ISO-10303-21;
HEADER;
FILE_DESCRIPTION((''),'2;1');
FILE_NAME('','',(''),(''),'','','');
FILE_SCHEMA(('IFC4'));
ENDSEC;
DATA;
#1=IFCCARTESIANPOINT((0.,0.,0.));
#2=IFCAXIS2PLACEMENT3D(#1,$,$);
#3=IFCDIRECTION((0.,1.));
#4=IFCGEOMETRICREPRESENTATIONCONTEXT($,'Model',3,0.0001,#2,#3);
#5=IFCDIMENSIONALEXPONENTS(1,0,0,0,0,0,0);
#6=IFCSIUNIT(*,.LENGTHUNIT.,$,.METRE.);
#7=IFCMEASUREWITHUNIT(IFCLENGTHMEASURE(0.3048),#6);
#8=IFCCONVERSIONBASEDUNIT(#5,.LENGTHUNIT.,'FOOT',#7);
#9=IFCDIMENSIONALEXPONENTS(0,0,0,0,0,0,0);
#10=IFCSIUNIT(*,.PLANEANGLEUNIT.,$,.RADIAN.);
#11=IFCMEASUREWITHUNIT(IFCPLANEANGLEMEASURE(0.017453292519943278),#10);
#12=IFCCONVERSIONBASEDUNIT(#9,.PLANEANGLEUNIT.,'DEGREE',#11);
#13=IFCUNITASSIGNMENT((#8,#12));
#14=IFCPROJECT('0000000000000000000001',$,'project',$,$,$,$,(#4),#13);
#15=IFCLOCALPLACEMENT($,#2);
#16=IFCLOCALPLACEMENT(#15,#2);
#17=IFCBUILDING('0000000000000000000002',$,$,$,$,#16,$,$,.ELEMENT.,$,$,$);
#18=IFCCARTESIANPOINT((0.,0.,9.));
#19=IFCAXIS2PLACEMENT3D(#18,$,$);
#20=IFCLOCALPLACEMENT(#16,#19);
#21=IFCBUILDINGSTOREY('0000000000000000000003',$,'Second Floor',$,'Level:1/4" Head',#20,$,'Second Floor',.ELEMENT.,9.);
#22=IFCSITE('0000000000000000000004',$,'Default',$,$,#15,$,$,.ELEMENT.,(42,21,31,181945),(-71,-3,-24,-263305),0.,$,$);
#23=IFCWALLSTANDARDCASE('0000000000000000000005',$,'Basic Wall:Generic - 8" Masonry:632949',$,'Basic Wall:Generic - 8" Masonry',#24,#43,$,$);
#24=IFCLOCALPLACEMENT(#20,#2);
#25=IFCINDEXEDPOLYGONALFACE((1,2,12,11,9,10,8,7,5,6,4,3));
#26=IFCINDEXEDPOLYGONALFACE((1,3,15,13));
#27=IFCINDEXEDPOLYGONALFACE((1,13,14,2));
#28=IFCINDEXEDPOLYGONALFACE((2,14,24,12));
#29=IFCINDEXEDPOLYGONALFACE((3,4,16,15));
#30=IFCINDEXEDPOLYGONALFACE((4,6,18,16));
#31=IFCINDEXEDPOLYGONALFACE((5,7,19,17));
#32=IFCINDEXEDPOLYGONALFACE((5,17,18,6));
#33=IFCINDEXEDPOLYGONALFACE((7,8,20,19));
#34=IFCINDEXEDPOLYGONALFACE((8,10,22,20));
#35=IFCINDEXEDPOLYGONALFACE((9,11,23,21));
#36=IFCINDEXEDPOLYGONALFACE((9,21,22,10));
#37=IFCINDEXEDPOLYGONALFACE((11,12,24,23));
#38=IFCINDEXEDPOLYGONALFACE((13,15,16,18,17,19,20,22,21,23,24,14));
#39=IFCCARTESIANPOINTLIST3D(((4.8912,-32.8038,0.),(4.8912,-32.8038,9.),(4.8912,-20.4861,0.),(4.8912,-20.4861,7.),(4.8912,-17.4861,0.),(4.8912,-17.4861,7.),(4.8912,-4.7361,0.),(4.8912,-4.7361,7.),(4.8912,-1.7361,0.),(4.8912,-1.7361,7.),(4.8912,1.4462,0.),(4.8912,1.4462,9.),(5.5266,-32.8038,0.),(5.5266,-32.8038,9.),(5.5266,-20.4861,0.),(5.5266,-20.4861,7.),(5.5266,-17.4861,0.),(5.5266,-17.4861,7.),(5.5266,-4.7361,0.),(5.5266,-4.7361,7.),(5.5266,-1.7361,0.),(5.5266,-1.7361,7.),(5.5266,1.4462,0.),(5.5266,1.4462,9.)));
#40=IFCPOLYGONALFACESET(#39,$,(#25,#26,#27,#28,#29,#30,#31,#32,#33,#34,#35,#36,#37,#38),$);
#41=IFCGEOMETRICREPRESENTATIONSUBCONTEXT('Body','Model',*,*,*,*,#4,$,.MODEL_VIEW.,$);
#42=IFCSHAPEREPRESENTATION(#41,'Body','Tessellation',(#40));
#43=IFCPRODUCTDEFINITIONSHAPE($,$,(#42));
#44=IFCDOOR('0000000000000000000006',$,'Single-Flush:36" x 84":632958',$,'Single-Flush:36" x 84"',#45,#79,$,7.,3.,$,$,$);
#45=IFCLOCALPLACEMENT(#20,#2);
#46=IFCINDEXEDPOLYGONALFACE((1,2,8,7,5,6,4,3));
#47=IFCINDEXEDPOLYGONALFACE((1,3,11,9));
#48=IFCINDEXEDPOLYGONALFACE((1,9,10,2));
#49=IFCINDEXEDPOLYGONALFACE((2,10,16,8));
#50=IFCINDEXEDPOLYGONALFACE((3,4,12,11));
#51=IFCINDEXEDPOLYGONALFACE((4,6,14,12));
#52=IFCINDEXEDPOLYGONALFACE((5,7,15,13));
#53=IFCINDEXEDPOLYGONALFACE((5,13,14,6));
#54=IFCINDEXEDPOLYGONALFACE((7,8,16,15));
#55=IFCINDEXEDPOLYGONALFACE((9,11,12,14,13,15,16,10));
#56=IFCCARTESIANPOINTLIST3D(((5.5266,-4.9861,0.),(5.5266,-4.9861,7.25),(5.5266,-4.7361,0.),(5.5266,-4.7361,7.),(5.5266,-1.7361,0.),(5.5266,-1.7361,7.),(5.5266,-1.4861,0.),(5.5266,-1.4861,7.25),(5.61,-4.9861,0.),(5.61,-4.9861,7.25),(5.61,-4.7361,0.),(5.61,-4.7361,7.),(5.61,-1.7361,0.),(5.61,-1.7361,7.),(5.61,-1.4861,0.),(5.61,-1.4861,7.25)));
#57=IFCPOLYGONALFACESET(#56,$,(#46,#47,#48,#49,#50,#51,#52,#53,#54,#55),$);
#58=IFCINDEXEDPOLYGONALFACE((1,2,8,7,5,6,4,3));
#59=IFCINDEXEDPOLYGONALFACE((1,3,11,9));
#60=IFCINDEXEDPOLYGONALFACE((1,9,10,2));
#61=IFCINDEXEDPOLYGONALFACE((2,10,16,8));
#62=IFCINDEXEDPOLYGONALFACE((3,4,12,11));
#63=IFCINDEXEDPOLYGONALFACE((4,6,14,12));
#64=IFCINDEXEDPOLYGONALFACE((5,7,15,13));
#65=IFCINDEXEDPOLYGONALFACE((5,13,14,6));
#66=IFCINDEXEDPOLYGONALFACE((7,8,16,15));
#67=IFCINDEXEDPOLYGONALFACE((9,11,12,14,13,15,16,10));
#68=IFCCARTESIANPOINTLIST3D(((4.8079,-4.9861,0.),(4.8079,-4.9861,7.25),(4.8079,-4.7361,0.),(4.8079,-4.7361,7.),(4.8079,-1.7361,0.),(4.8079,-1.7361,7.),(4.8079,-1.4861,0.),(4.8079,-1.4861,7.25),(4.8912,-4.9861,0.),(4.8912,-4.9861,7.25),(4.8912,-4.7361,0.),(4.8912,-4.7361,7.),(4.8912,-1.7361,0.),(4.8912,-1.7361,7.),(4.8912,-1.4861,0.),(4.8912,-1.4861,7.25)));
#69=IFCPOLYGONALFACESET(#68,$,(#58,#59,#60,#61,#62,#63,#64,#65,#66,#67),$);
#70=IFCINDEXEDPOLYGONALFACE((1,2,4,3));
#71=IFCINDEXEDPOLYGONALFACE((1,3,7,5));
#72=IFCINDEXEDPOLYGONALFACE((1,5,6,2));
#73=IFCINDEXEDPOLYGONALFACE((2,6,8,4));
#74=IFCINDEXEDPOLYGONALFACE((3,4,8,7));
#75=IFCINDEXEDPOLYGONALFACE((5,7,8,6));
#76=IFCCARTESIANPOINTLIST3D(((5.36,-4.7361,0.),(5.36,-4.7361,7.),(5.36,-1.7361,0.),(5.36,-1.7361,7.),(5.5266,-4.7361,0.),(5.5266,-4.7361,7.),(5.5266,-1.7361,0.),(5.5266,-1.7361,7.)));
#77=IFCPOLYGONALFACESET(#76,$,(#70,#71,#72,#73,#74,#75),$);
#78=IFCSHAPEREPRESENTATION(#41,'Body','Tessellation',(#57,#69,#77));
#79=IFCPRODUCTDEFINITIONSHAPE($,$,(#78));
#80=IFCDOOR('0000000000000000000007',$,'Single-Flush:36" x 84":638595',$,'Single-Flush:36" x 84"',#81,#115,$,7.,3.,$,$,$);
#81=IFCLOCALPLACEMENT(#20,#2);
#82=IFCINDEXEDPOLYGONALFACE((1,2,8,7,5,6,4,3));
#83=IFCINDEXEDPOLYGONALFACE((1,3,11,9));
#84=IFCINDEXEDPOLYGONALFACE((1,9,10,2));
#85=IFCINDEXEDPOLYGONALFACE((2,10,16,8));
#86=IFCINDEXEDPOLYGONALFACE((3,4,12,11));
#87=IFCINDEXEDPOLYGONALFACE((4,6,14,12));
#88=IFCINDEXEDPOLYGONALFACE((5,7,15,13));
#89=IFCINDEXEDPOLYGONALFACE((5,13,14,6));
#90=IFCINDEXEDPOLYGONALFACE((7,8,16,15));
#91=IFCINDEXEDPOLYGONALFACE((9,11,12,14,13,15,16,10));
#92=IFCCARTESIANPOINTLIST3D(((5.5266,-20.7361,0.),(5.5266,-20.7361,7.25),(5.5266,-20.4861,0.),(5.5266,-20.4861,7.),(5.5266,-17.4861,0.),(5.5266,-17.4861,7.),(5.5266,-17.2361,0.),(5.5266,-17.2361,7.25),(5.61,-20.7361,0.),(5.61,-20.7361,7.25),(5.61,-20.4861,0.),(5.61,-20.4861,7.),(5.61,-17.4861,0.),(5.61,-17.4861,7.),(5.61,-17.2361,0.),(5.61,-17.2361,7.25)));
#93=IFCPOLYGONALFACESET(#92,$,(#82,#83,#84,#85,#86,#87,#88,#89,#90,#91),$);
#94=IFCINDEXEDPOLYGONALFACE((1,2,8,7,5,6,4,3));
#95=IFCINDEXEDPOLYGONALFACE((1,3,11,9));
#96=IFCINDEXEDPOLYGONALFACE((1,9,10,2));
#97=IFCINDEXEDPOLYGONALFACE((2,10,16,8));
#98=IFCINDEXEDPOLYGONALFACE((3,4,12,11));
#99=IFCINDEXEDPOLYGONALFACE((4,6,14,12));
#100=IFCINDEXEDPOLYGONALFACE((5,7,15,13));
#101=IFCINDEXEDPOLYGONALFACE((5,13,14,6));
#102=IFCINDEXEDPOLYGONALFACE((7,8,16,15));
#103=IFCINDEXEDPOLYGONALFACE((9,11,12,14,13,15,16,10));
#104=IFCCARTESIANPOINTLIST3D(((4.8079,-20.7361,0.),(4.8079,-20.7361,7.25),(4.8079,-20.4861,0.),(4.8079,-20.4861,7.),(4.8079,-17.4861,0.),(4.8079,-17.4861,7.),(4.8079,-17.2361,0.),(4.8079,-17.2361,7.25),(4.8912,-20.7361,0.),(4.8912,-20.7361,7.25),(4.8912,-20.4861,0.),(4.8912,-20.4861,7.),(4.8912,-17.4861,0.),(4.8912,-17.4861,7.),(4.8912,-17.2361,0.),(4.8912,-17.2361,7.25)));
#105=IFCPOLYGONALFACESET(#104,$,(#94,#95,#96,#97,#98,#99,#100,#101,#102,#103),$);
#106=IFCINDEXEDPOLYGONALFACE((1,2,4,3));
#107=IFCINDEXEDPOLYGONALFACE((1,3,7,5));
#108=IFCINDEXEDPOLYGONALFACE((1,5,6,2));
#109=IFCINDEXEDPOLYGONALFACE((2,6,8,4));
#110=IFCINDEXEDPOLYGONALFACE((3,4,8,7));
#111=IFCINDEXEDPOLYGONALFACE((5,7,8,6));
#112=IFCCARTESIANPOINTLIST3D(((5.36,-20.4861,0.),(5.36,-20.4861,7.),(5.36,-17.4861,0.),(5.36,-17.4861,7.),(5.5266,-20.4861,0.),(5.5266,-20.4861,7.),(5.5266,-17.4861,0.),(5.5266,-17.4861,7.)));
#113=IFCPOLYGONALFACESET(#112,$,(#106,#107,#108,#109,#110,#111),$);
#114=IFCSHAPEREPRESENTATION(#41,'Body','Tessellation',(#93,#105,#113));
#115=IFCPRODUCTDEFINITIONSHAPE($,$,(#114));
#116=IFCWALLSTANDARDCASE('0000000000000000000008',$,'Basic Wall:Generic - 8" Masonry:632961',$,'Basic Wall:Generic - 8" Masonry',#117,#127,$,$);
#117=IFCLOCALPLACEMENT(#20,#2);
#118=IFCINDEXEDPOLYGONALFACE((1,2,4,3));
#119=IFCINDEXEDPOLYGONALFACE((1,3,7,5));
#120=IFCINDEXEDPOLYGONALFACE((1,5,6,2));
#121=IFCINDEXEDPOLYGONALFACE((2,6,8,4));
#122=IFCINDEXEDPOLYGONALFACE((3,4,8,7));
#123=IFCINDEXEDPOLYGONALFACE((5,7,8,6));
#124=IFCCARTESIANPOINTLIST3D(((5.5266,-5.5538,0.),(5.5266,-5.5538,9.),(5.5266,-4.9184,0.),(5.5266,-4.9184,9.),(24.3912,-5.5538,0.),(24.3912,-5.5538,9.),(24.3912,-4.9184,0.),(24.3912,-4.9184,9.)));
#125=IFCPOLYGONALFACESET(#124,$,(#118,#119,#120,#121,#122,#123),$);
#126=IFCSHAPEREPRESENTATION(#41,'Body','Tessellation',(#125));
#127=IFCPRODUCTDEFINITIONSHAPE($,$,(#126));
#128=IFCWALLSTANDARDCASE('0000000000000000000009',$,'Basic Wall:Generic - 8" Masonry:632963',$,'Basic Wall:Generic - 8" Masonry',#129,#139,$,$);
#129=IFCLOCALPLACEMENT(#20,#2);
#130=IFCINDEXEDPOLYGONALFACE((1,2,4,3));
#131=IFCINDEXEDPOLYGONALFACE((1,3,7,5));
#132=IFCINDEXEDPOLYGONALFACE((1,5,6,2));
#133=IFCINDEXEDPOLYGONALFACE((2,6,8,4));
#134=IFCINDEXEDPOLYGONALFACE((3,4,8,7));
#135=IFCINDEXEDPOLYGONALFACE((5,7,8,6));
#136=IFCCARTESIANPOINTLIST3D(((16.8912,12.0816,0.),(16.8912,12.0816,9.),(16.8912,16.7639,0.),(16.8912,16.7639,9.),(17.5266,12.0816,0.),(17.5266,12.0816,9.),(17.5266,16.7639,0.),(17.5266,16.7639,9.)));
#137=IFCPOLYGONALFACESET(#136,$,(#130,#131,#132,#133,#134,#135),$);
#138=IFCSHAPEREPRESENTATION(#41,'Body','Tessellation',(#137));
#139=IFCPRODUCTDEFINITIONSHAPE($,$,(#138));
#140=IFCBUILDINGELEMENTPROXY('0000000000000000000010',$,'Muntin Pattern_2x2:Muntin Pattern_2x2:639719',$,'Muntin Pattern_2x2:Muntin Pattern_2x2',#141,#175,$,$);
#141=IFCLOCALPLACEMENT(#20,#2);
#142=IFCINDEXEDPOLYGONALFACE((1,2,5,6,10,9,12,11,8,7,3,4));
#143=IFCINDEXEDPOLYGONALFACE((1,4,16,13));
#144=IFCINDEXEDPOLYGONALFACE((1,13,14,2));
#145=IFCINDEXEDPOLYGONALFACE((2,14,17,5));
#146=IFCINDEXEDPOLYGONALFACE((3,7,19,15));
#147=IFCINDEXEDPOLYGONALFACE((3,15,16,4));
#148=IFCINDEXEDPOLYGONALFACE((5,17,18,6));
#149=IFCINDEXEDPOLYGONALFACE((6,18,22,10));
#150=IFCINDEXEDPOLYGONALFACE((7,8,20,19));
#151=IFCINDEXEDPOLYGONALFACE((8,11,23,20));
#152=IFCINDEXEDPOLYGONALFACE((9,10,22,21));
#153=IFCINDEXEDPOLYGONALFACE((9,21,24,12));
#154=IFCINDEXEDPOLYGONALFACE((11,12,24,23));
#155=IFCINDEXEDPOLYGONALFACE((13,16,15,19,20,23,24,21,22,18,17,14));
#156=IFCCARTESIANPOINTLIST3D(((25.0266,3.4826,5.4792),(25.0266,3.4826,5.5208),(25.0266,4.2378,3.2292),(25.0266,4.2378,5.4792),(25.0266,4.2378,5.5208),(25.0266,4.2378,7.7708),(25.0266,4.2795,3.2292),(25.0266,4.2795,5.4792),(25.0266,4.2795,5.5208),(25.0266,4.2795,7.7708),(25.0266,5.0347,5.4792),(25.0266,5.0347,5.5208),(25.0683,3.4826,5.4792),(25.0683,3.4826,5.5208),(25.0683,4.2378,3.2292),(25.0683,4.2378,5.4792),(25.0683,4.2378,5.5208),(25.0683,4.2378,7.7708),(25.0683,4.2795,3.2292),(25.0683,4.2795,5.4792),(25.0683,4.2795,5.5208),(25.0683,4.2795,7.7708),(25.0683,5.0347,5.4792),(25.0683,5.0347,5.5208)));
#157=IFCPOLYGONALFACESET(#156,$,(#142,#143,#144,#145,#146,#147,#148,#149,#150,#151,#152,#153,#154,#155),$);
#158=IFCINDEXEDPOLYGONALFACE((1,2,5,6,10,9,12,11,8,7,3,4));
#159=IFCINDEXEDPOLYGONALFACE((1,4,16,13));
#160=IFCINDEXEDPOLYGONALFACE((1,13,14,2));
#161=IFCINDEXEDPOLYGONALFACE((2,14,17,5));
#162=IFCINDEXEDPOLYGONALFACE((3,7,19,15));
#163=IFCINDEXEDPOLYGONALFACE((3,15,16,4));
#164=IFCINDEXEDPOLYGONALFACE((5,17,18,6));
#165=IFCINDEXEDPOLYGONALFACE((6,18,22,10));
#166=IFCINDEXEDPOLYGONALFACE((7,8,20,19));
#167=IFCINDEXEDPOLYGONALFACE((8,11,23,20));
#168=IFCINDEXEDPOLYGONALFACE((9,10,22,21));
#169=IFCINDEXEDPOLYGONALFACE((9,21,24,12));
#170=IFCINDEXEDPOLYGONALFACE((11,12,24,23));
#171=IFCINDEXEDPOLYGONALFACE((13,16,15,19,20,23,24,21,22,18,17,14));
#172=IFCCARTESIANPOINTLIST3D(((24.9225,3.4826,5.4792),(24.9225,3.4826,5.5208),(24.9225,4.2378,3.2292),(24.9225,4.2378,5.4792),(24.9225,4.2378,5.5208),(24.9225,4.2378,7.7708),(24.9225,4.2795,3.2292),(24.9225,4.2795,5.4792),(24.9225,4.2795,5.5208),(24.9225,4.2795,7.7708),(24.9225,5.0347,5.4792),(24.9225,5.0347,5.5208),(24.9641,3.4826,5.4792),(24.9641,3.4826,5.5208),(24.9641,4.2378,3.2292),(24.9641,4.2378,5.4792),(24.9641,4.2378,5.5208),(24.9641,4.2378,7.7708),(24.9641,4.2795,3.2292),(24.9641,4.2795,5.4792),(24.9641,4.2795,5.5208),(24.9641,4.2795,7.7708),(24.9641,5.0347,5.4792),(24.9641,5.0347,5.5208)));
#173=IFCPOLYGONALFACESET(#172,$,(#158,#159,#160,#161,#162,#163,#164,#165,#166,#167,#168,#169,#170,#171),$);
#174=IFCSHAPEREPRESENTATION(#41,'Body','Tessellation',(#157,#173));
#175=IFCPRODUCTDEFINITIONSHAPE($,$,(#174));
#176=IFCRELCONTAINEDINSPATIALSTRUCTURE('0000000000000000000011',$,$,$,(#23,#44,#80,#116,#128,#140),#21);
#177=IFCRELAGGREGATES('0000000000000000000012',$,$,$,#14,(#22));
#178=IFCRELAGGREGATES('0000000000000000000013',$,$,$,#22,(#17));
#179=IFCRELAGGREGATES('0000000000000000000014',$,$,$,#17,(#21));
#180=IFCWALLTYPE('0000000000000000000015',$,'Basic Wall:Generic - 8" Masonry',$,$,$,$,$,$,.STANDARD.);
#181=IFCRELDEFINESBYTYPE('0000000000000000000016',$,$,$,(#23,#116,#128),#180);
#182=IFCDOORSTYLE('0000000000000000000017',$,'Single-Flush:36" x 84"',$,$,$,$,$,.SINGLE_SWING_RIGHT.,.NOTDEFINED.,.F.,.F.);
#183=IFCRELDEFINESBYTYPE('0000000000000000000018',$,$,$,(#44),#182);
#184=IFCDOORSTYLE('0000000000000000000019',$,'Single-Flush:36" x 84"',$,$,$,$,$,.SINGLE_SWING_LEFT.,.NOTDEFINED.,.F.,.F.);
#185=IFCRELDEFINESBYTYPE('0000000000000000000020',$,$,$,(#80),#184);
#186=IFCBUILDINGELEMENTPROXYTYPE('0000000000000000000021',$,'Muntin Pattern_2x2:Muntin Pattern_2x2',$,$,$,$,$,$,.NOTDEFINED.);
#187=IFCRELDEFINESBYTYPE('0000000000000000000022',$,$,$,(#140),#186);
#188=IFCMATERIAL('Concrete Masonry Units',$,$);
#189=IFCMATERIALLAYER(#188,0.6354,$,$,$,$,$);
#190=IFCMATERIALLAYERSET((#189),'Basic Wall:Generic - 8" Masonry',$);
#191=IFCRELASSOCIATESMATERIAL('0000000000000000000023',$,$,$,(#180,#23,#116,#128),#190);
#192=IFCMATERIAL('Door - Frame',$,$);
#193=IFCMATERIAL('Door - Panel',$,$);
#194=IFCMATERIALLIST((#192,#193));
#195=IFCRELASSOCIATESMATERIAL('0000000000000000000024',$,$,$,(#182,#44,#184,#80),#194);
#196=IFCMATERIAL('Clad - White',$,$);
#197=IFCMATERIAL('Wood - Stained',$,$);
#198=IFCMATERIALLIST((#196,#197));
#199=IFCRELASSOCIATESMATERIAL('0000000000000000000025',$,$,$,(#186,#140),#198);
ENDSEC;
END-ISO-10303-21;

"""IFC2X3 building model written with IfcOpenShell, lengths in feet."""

from ifc_helpers import new_model, entity, si_unit, converted_unit, direction, frame, frame_2d, origin, place, context, subcontext, project, spatial, polyline, rectangle, outline, extrude, source, transform, mapped, material, material_list, layer, layer_set, layer_usage, type_object, type_shapes, element, fill, save


model = new_model("IFC2X3")

# Units and contexts
model_context = context("Model", 3, precision=0.0001, world=origin(), true_north=direction((0.0, 1.0)))
body_context = subcontext(model_context, "Body", "Model", "MODEL_VIEW")
ifc_project = project(units=[converted_unit("LENGTHUNIT", "FOOT", entity("IfcLengthMeasure", 0.3048), si_unit("LENGTHUNIT", "METRE"), dimensions=[1, 0, 0, 0, 0, 0, 0]), converted_unit("PLANEANGLEUNIT", "DEGREE", entity("IfcPlaneAngleMeasure", 0.017453292519943278), si_unit("PLANEANGLEUNIT", "RADIAN"), dimensions=[0, 0, 0, 0, 0, 0, 0])], contexts=[model_context])

# Site, building, storey
site_placement = place(None, origin())
site = spatial("IfcSite", under=ifc_project, at=site_placement, Name="Default", CompositionType="ELEMENT", RefLatitude=(42, 21, 31, 181945), RefLongitude=(-71, -3, -24, -263305), RefElevation=0.0)
building_placement = place(site_placement, origin())
building = spatial("IfcBuilding", under=site, at=building_placement, CompositionType="ELEMENT")
storey_placement = place(building_placement, frame((0.0, 0.0, 9.0)))
storey = spatial("IfcBuildingStorey", under=building, at=storey_placement, Name="Second Floor", ObjectType="Level:1/4\" Head", LongName="Second Floor", CompositionType="ELEMENT", Elevation=9.0)

# Shared definitions
ifc_material_1 = material(Name="Concrete Masonry Units")
ifc_layer_1 = layer(ifc_material_1, 0.6354)
ifc_layer_set_1 = layer_set([ifc_layer_1], Name="Basic Wall:Generic - 8\" Masonry")
wall_type = type_object("IfcWallType", Name="Basic Wall:Generic - 8\" Masonry", PredefinedType="STANDARD", material=ifc_layer_set_1)

# Wall, openings, doors
ifc_layer_usage_1 = layer_usage(ifc_layer_set_1, "AXIS2", "NEGATIVE", 0.3177)
wall_1_placement = place(storey_placement, frame((5.2089, 1.4462, 0.0), z_axis=(0.0, 0.0, 1.0), x_axis=(0.0, -1.0, 0.0)))
wall_1 = element("IfcWallStandardCase", 1, at=wall_1_placement, inside=storey, type_object=wall_type, material=ifc_layer_usage_1, Name="Basic Wall:Generic - 8\" Masonry:632949", ObjectType="Basic Wall:Generic - 8\" Masonry", context=body_context, shape_type="SweptSolid", body=[
    extrude(rectangle(XDim=34.25, YDim=0.6354, at=frame_2d((17.125, 0.0), x_axis=(1.0, 0.0))), origin(), (0.0, 0.0, 1.0), 9.0),
])
opening_1_placement = place(wall_1_placement, frame((3.1823, -0.3177, 0.0)))
opening_1 = element("IfcOpeningElement", 2, at=opening_1_placement, cuts=wall_1, ObjectType="Opening", context=body_context, shape_type="SweptSolid", body=[
    extrude(rectangle(XDim=3.0, YDim=7.0, at=frame_2d((3.5, 1.5), x_axis=(0.0, 1.0))), frame((0.0, 0.0, 0.0), z_axis=(0.0, 1.0, 0.0), x_axis=(0.0, 0.0, 1.0)), (0.0, 0.0, 1.0), 0.6354),
])
opening_2_placement = place(wall_1_placement, frame((18.9323, -0.3177, 0.0)))
opening_2 = element("IfcOpeningElement", 3, at=opening_2_placement, cuts=wall_1, ObjectType="Opening", context=body_context, shape_type="SweptSolid", body=[
    extrude(rectangle(XDim=3.0, YDim=7.0, at=frame_2d((3.5, 1.5), x_axis=(0.0, -1.0))), frame((0.0, 0.0, 0.0), z_axis=(0.0, 1.0, 0.0), x_axis=(0.0, 0.0, 1.0)), (0.0, 0.0, 1.0), 0.6354),
])
ifc_material_2 = material(Name="Door - Frame")
ifc_material_3 = material(Name="Door - Panel")
ifc_material_list_1 = material_list([ifc_material_2, ifc_material_3])
door_style_1 = type_object("IfcDoorStyle", Name="Single-Flush:36\" x 84\"", ConstructionType="NOTDEFINED", OperationType="SINGLE_SWING_RIGHT", ParameterTakesPrecedence=False, Sizeable=False, material=ifc_material_list_1)
shared_shape_1 = source(origin(), body_context, "Body", "SweptSolid", [
    extrude(outline(polyline([(-1.75, -3.6875), (1.75, -3.6875), (1.75, 3.5625), (1.5, 3.5625), (1.5, -3.4375), (-1.5, -3.4375), (-1.5, 3.5625), (-1.75, 3.5625), (-1.75, -3.6875)])), frame((1.5, 0.6354, 3.5625), z_axis=(0.0, 1.0, 0.0), x_axis=(1.0, 0.0, 0.0)), (0.0, 0.0, 1.0), 0.0833),
    extrude(outline(polyline([(-3.6875, -1.75), (3.5625, -1.75), (3.5625, -1.5), (-3.4375, -1.5), (-3.4375, 1.5), (3.5625, 1.5), (3.5625, 1.75), (-3.6875, 1.75), (-3.6875, -1.75)])), frame((1.5, -0.0833, 3.5625), z_axis=(0.0, 1.0, 0.0), x_axis=(0.0, 0.0, -1.0)), (0.0, 0.0, 1.0), 0.0833),
    extrude(rectangle(XDim=0.1667, YDim=3.0, at=frame_2d((0.0, 0.0), x_axis=(1.0, 0.0))), frame((1.5, 0.5521, 0.0), z_axis=(0.0, 0.0, 1.0), x_axis=(0.0, 1.0, 0.0)), (0.0, 0.0, 1.0), 7.0),
])
type_shapes(door_style_1, [shared_shape_1])
door_1_placement = place(opening_1_placement, origin())
door_1 = element("IfcDoor", 4, at=door_1_placement, inside=storey, type_object=door_style_1, material=ifc_material_list_1, Name="Single-Flush:36\" x 84\":632958", ObjectType="Single-Flush:36\" x 84\"", OverallHeight=7.0, OverallWidth=3.0, context=body_context, shape_type="MappedRepresentation", body=[
    mapped(shared_shape_1, transform((0.0, 0.0, 0.0), scale=1.0)),
])
fill(opening_1, door_1)
door_style_2 = type_object("IfcDoorStyle", Name="Single-Flush:36\" x 84\"", ConstructionType="NOTDEFINED", OperationType="SINGLE_SWING_LEFT", ParameterTakesPrecedence=False, Sizeable=False, material=ifc_material_list_1)
shared_shape_2 = source(origin(), body_context, "Body", "SweptSolid", [
    extrude(outline(polyline([(-1.75, -3.6875), (1.75, -3.6875), (1.75, 3.5625), (1.5, 3.5625), (1.5, -3.4375), (-1.5, -3.4375), (-1.5, 3.5625), (-1.75, 3.5625), (-1.75, -3.6875)])), frame((1.5, 0.7187, 3.5625), z_axis=(0.0, -1.0, 0.0), x_axis=(-1.0, 0.0, 0.0)), (0.0, 0.0, 1.0), 0.0833),
    extrude(outline(polyline([(-3.6875, -1.75), (3.5625, -1.75), (3.5625, -1.5), (-3.4375, -1.5), (-3.4375, 1.5), (3.5625, 1.5), (3.5625, 1.75), (-3.6875, 1.75), (-3.6875, -1.75)])), frame((1.5, 0.0, 3.5625), z_axis=(0.0, -1.0, 0.0), x_axis=(0.0, 0.0, -1.0)), (0.0, 0.0, 1.0), 0.0833),
    extrude(rectangle(XDim=3.0, YDim=0.1667, at=frame_2d((0.0, 0.0), x_axis=(1.0, 0.0))), frame((1.5, 0.5521, 0.0)), (0.0, 0.0, 1.0), 7.0),
])
type_shapes(door_style_2, [shared_shape_2])
door_2_placement = place(opening_2_placement, origin())
door_2 = element("IfcDoor", 5, at=door_2_placement, inside=storey, type_object=door_style_2, material=ifc_material_list_1, Name="Single-Flush:36\" x 84\":638595", ObjectType="Single-Flush:36\" x 84\"", OverallHeight=7.0, OverallWidth=3.0, context=body_context, shape_type="MappedRepresentation", body=[
    mapped(shared_shape_2, transform((0.0, 0.0, 0.0), scale=1.0)),
])
fill(opening_2, door_2)

# Walls
ifc_layer_usage_2 = layer_usage(ifc_layer_set_1, "AXIS2", "NEGATIVE", 0.3177)
wall_2_placement = place(storey_placement, frame((5.5266, -5.2361, 0.0)))
element("IfcWallStandardCase", 6, at=wall_2_placement, inside=storey, type_object=wall_type, material=ifc_layer_usage_2, Name="Basic Wall:Generic - 8\" Masonry:632961", ObjectType="Basic Wall:Generic - 8\" Masonry", context=body_context, shape_type="SweptSolid", body=[
    extrude(rectangle(XDim=18.8646, YDim=0.6354, at=frame_2d((9.4323, 0.0), x_axis=(-1.0, 0.0))), origin(), (0.0, 0.0, 1.0), 9.0),
])
ifc_layer_usage_3 = layer_usage(ifc_layer_set_1, "AXIS2", "NEGATIVE", 0.3177)
wall_3_placement = place(storey_placement, frame((17.2089, 12.0816, 0.0), z_axis=(0.0, 0.0, 1.0), x_axis=(0.0, 1.0, 0.0)))
element("IfcWallStandardCase", 7, at=wall_3_placement, inside=storey, type_object=wall_type, material=ifc_layer_usage_3, Name="Basic Wall:Generic - 8\" Masonry:632963", ObjectType="Basic Wall:Generic - 8\" Masonry", context=body_context, shape_type="SweptSolid", body=[
    extrude(rectangle(XDim=4.6823, YDim=0.6354, at=frame_2d((2.3411, 0.0), x_axis=(-1.0, 0.0))), origin(), (0.0, 0.0, 1.0), 9.0),
])

# Building element proxy
ifc_material_4 = material(Name="Clad - White")
ifc_material_5 = material(Name="Wood - Stained")
ifc_material_list_2 = material_list([ifc_material_4, ifc_material_5])
building_element_proxy_type_1 = type_object("IfcBuildingElementProxyType", Name="Muntin Pattern_2x2:Muntin Pattern_2x2", PredefinedType="NOTDEFINED", material=ifc_material_list_2)
shared_shape_3 = source(origin(), body_context, "Body", "SweptSolid", [
    extrude(outline(polyline([(0.0208, -0.0208), (2.2708, -0.0208), (2.2708, 0.0208), (0.0208, 0.0208), (0.0208, 0.776), (-0.0208, 0.776), (-0.0208, 0.0208), (-2.2708, 0.0208), (-2.2708, -0.0208), (-0.0208, -0.0208), (-0.0208, -0.776), (0.0208, -0.776), (0.0208, -0.0208)])), frame((0.0, 0.0313, 2.2708), z_axis=(0.0, 1.0, 0.0), x_axis=(0.0, 0.0, 1.0)), (0.0, 0.0, 1.0), 0.0417),
    extrude(outline(polyline([(0.0208, -0.0208), (2.2708, -0.0208), (2.2708, 0.0208), (0.0208, 0.0208), (0.0208, 0.776), (-0.0208, 0.776), (-0.0208, 0.0208), (-2.2708, 0.0208), (-2.2708, -0.0208), (-0.0208, -0.0208), (-0.0208, -0.776), (0.0208, -0.776), (0.0208, -0.0208)])), frame((0.0, -0.0729, 2.2708), z_axis=(0.0, 1.0, 0.0), x_axis=(0.0, 0.0, 1.0)), (0.0, 0.0, 1.0), 0.0417),
])
type_shapes(building_element_proxy_type_1, [shared_shape_3])
for number, where, z_axis, x_axis, name in (
    (8, (24.9954, 4.2587, 3.2292), (0.0, 0.0, 1.0), (0.0, -1.0, 0.0), "Muntin Pattern_2x2:Muntin Pattern_2x2:639719"),
):
    element("IfcBuildingElementProxy", number, at=place(storey_placement, frame(where, z_axis=z_axis, x_axis=x_axis)), inside=storey, type_object=building_element_proxy_type_1, material=ifc_material_list_2, Name=name, ObjectType="Muntin Pattern_2x2:Muntin Pattern_2x2", context=body_context, shape_type="MappedRepresentation", body=[
        mapped(shared_shape_3, transform((0.0, 0.0, 0.0), scale=1.0)),
    ])

save(model, "model.ifc")
